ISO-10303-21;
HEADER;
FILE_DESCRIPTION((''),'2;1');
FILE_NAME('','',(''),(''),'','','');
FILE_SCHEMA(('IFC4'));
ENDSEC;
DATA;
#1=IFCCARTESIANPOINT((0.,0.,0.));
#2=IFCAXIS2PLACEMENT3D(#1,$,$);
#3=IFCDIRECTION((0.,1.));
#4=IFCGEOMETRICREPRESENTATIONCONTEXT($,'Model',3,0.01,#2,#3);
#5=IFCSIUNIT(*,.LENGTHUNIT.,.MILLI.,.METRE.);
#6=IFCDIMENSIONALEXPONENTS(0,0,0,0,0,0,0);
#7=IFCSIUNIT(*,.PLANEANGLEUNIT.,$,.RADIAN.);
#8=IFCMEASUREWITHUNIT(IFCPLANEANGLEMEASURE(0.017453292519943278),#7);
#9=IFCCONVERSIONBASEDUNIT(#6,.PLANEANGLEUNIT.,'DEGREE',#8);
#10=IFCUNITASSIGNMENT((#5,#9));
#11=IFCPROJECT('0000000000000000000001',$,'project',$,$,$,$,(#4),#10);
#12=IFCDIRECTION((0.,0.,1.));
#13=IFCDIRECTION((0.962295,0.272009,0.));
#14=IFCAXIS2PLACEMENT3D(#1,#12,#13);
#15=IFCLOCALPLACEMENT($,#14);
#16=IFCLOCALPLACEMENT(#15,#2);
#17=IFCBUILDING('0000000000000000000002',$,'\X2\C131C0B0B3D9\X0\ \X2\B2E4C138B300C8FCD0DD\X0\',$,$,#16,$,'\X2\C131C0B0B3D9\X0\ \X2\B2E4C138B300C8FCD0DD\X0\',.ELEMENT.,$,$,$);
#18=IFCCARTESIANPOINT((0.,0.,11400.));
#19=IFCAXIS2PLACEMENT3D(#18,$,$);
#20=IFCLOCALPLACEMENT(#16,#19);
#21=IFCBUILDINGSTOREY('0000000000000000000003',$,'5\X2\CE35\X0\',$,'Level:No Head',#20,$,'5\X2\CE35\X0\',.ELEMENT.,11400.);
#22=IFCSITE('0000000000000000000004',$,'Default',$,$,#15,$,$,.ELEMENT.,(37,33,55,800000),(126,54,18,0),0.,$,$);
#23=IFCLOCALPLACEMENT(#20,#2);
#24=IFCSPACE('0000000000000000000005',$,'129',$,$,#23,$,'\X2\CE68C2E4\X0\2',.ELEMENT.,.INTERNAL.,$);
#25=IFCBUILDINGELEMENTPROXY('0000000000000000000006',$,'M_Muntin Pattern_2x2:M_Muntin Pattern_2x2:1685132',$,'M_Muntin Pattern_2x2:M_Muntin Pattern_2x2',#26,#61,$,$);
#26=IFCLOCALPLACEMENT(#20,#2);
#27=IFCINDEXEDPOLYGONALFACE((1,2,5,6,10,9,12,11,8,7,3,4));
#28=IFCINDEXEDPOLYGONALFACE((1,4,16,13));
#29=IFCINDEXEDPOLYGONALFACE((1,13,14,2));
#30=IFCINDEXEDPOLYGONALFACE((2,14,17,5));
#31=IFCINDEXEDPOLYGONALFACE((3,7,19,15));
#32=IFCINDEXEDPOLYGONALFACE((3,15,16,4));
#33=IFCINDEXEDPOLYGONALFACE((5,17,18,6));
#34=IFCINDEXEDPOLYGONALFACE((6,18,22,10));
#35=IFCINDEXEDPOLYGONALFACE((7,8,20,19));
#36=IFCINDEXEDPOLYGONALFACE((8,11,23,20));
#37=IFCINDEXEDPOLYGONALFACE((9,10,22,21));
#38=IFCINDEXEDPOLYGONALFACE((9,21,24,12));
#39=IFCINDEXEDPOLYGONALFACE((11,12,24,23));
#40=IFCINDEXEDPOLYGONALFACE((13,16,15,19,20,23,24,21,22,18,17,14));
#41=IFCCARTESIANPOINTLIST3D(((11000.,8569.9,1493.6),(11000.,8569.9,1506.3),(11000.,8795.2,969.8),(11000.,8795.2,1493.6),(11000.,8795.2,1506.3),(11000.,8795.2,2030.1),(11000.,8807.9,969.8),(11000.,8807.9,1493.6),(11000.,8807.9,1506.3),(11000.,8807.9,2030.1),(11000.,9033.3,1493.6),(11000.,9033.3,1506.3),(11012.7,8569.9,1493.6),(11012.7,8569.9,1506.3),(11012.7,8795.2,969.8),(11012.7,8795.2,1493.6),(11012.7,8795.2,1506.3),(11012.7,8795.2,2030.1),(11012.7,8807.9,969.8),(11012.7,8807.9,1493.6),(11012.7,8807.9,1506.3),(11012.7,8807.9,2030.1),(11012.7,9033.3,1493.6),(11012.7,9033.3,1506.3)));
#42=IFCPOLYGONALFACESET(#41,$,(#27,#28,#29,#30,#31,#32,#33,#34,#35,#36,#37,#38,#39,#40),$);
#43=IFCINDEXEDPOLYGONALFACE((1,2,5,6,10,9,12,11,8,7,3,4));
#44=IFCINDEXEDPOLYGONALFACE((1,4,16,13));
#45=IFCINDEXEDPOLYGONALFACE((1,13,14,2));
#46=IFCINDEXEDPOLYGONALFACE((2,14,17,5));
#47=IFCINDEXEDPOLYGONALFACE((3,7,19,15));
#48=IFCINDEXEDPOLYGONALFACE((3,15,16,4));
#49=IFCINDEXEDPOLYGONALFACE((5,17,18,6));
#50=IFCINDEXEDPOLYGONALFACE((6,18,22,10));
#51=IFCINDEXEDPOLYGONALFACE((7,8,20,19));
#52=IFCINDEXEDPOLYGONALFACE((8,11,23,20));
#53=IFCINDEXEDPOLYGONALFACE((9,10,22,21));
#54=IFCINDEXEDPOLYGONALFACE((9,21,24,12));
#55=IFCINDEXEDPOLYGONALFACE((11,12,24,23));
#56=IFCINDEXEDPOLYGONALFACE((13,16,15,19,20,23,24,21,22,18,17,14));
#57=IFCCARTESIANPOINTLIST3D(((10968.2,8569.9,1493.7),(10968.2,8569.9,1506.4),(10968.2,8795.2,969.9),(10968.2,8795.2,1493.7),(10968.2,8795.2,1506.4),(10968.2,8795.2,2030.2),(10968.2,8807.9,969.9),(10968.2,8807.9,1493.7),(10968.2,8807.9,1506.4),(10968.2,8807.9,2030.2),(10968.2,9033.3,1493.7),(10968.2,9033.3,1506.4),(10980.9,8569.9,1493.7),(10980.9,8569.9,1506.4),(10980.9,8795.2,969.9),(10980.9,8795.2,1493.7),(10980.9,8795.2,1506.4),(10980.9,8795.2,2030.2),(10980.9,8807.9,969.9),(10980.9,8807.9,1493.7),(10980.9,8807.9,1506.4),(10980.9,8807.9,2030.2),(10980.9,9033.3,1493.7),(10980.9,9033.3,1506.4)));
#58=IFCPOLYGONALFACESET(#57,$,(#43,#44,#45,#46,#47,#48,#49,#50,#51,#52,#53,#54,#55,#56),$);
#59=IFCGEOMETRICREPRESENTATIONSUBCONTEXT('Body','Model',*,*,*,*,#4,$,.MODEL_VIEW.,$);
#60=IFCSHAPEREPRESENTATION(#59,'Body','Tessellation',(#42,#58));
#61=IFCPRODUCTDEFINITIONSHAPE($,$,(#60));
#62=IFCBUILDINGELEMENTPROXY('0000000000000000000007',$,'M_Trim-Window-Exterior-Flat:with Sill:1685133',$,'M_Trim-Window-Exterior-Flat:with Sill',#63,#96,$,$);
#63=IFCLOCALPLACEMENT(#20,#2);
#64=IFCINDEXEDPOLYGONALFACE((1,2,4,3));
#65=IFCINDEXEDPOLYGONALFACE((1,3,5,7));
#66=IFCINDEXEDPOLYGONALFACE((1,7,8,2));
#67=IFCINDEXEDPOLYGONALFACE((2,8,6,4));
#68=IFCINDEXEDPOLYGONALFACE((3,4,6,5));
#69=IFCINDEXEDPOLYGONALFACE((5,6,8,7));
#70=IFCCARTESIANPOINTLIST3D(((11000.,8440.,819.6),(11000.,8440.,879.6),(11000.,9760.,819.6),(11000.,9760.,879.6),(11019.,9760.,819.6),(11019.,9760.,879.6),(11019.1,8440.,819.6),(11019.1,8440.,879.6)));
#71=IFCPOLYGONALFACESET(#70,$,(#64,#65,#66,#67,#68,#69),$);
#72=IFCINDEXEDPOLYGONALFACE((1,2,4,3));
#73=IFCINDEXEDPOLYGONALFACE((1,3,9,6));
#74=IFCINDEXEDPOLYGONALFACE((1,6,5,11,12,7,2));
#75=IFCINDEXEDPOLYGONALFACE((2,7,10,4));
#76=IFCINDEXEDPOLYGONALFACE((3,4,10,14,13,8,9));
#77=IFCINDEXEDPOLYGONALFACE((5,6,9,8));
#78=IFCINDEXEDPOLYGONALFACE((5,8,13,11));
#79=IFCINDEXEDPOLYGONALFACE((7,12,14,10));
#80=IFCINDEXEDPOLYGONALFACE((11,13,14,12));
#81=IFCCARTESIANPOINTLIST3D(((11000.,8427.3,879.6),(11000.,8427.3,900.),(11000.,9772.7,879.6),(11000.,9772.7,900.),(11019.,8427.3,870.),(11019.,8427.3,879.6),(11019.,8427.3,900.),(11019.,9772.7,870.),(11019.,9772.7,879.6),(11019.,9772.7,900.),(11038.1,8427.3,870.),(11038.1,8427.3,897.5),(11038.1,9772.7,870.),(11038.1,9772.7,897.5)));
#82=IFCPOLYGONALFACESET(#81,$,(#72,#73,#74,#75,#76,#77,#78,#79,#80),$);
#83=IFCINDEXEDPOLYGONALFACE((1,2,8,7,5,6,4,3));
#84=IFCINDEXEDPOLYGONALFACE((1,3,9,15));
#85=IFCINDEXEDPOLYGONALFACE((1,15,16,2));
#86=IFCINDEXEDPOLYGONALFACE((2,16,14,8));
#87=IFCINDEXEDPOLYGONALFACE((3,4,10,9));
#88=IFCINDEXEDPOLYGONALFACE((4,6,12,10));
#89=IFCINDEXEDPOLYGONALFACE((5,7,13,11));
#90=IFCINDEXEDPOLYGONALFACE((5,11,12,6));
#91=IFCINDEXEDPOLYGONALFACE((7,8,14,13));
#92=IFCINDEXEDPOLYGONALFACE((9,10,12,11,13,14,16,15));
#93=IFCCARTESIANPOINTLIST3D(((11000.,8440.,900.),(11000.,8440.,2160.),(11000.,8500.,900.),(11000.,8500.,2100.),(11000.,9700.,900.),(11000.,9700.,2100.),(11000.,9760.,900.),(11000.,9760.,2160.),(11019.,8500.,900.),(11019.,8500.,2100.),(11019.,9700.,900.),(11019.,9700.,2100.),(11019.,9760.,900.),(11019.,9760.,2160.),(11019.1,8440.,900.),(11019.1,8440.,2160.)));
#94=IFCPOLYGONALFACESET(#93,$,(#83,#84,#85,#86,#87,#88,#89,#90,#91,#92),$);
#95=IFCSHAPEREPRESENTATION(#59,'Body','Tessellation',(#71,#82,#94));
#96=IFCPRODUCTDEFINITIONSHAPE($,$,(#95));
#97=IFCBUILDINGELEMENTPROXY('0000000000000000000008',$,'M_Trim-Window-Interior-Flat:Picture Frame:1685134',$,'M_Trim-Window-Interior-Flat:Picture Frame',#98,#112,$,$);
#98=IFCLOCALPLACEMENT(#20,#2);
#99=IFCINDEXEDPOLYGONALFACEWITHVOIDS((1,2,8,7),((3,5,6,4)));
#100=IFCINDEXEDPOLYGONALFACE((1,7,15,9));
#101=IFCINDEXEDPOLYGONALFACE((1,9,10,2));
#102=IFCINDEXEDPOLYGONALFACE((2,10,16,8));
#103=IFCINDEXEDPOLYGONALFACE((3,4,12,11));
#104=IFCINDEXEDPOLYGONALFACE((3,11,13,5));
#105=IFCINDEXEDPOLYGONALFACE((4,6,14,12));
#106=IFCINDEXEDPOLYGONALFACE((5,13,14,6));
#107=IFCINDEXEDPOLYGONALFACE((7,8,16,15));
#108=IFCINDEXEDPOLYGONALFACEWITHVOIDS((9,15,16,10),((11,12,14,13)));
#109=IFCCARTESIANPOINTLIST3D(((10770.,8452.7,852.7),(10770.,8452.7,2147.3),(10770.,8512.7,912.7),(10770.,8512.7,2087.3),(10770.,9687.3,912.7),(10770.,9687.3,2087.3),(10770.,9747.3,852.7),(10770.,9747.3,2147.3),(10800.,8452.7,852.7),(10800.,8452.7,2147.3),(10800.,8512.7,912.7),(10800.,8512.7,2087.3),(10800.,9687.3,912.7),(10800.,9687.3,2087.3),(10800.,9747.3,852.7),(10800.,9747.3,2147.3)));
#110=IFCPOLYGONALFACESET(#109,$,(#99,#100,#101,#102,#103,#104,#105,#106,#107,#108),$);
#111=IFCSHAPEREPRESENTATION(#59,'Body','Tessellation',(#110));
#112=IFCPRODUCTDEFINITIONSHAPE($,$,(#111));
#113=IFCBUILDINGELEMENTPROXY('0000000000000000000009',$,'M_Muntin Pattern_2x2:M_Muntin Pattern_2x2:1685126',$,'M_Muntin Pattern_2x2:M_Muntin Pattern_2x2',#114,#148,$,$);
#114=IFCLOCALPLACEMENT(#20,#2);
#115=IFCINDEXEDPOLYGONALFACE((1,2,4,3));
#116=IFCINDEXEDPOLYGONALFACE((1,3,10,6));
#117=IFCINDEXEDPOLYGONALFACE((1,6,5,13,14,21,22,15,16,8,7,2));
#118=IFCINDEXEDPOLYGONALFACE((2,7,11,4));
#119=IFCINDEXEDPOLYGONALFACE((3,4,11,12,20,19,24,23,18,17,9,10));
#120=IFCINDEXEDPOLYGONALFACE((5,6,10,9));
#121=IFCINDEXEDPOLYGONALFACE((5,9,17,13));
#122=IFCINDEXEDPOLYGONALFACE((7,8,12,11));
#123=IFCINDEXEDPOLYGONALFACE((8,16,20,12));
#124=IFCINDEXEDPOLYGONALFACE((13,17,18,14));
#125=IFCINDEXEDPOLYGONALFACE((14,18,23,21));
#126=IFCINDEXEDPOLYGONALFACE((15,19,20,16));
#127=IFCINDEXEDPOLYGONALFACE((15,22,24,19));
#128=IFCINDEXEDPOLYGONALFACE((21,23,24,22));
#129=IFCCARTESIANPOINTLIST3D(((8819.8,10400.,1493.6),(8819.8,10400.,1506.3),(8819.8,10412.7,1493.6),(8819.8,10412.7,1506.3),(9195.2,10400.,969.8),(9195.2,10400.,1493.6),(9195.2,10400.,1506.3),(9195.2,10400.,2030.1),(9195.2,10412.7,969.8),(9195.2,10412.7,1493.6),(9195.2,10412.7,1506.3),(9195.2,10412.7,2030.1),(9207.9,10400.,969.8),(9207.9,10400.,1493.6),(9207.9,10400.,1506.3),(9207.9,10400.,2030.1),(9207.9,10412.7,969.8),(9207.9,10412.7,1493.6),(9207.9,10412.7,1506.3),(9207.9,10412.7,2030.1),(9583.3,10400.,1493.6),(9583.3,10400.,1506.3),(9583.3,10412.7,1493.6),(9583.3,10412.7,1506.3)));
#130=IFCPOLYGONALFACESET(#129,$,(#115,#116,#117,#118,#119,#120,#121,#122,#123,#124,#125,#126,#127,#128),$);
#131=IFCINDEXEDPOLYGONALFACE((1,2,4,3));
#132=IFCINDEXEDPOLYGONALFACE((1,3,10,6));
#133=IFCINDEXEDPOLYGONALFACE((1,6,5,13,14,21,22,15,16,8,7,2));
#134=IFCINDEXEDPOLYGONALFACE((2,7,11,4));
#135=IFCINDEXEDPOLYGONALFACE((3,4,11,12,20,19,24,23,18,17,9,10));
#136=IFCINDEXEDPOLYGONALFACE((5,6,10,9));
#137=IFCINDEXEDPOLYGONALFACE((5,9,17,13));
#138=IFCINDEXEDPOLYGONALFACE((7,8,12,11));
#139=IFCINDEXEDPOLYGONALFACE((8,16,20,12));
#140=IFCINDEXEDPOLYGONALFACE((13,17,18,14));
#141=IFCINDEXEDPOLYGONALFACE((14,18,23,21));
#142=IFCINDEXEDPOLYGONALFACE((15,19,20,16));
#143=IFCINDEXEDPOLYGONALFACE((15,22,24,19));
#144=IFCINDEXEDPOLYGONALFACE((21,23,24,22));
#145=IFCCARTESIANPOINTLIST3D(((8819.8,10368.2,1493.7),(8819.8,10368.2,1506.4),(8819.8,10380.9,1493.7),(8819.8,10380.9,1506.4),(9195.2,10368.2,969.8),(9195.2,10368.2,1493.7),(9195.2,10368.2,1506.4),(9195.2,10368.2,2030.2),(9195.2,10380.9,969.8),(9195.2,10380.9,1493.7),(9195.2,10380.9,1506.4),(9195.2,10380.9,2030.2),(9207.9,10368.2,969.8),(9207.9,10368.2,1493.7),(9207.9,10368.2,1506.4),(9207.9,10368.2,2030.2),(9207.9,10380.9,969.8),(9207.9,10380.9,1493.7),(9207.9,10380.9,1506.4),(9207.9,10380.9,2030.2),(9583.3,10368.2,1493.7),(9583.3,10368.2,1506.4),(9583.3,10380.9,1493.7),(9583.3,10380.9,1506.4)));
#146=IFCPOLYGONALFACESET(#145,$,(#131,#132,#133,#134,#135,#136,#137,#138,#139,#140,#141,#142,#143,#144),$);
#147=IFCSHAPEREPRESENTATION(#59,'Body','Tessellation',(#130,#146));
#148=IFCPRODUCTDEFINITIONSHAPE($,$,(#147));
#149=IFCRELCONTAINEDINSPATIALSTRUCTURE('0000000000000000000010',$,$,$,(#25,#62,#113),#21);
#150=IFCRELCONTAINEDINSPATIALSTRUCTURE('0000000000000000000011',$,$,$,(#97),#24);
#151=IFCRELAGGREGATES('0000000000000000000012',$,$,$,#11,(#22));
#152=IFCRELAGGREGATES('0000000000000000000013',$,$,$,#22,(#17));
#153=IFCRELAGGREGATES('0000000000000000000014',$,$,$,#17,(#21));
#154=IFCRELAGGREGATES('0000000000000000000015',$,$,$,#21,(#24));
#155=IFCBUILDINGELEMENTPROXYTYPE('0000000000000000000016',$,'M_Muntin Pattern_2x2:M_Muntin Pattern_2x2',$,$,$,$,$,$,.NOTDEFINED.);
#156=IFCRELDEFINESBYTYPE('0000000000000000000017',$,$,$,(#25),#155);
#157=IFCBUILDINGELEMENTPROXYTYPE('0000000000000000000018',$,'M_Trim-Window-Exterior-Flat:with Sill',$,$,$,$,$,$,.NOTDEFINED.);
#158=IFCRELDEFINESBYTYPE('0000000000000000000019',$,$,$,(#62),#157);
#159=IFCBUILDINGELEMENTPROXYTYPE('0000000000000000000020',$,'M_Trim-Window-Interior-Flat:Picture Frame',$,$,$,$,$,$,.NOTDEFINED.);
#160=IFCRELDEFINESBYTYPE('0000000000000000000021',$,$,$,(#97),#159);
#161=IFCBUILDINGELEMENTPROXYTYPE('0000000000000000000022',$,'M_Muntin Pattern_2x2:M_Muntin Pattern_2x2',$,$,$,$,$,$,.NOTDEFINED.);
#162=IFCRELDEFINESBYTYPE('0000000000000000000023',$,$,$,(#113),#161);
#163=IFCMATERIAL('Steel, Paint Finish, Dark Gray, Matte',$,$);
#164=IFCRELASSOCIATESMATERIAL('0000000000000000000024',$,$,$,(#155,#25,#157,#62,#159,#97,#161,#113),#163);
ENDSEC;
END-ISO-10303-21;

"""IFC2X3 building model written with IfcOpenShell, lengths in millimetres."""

from ifc_helpers import new_model, entity, si_unit, converted_unit, direction, frame, frame_2d, origin, place, context, subcontext, project, spatial, polyline, rectangle, outline, extrude, source, transform, mapped, material, type_object, type_shapes, element, save


model = new_model("IFC2X3")

# Units and contexts
model_context = context("Model", 3, precision=0.01, world=origin(), true_north=direction((0.0, 1.0)))
body_context = subcontext(model_context, "Body", "Model", "MODEL_VIEW")
ifc_project = project(units=[si_unit("LENGTHUNIT", "METRE", prefix="MILLI"), converted_unit("PLANEANGLEUNIT", "DEGREE", entity("IfcPlaneAngleMeasure", 0.017453292519943278), si_unit("PLANEANGLEUNIT", "RADIAN"), dimensions=[0, 0, 0, 0, 0, 0, 0])], contexts=[model_context])

# Site, building, storey
site_placement = place(None, frame((0.0, 0.0, 0.0), z_axis=(0.0, 0.0, 1.0), x_axis=(0.962295, 0.272009, 0.0)))
site = spatial("IfcSite", under=ifc_project, at=site_placement, Name="Default", CompositionType="ELEMENT", RefLatitude=(37, 33, 55, 800000), RefLongitude=(126, 54, 18, 0), RefElevation=0.0)
building_placement = place(site_placement, origin())
building = spatial("IfcBuilding", under=site, at=building_placement, Name="성산동 다세대주택", LongName="성산동 다세대주택", CompositionType="ELEMENT")
storey_placement = place(building_placement, frame((0.0, 0.0, 11400.0)))
storey = spatial("IfcBuildingStorey", under=building, at=storey_placement, Name="5층", ObjectType="Level:No Head", LongName="5층", CompositionType="ELEMENT", Elevation=11400.0)

# Shared definitions
space_1_placement = place(storey_placement, origin())
space_1 = spatial("IfcSpace", under=storey, at=space_1_placement, Name="129", LongName="침실2", CompositionType="ELEMENT", InteriorOrExteriorSpace="INTERNAL")

# Building element proxies
ifc_material_1 = material(Name="Steel, Paint Finish, Dark Gray, Matte")
building_element_proxy_type_1 = type_object("IfcBuildingElementProxyType", Name="M_Muntin Pattern_2x2:M_Muntin Pattern_2x2", PredefinedType="NOTDEFINED", material=ifc_material_1)
shared_shape_1 = source(origin(), body_context, "Body", "SweptSolid", [
    extrude(outline(polyline([(6.4, -6.4), (530.1, -6.4), (530.1, 6.3), (6.4, 6.3), (6.4, 231.7), (-6.3, 231.7), (-6.3, 6.3), (-530.2, 6.3), (-530.2, -6.4), (-6.3, -6.4), (-6.3, -231.7), (6.4, -231.7), (6.4, -6.4)])), frame((0.0, -22.2, 530.1), z_axis=(0.0, 1.0, 0.0), x_axis=(0.0, 0.0, 1.0)), (0.0, 0.0, 1.0), 12.7),
    extrude(outline(polyline([(6.4, -6.4), (530.2, -6.4), (530.2, 6.3), (6.4, 6.3), (6.4, 231.7), (-6.3, 231.7), (-6.3, 6.3), (-530.2, 6.3), (-530.2, -6.4), (-6.3, -6.4), (-6.3, -231.7), (6.4, -231.7), (6.4, -6.4)])), frame((0.0, 9.5, 530.2), z_axis=(0.0, 1.0, 0.0), x_axis=(0.0, 0.0, 1.0)), (0.0, 0.0, 1.0), 12.7),
])
type_shapes(building_element_proxy_type_1, [shared_shape_1])
proxy_1_placement = place(storey_placement, frame((10990.5, 8801.6, 969.9), z_axis=(0.0, 0.0, 1.0), x_axis=(0.0, 1.0, 0.0)))
element("IfcBuildingElementProxy", 1, at=proxy_1_placement, inside=storey, type_object=building_element_proxy_type_1, material=ifc_material_1, Name="M_Muntin Pattern_2x2:M_Muntin Pattern_2x2:1685132", ObjectType="M_Muntin Pattern_2x2:M_Muntin Pattern_2x2", context=body_context, shape_type="MappedRepresentation", body=[
    mapped(shared_shape_1, transform((0.0, 0.0, 0.0), scale=1.0)),
])
building_element_proxy_type_2 = type_object("IfcBuildingElementProxyType", Name="M_Trim-Window-Exterior-Flat:with Sill", PredefinedType="NOTDEFINED", material=ifc_material_1)
shared_shape_2 = source(origin(), body_context, "Body", "SweptSolid", [
    extrude(rectangle(XDim=1320.0, YDim=60.0, at=frame_2d((0.0, 0.0), x_axis=(1.0, 0.0))), frame((0.0, -1250.4, 0.0), z_axis=(0.0, 0.0, 1.0), x_axis=(-1.0, 0.0, 0.0)), (0.0, 0.0, 1.0), 19.0),
    extrude(outline(polyline([(-19.0, -15.2), (0.0, -15.2), (0.0, -5.7), (19.0, -5.7), (19.0, 14.8), (0.0, 14.8), (-19.0, 12.3), (-19.0, -15.2)])), frame((-672.7, -1214.8, 19.0), z_axis=(1.0, 0.0, 0.0), x_axis=(0.0, 0.0, -1.0)), (0.0, 0.0, 1.0), 1345.4),
    extrude(outline(polyline([(-645.0, -660.0), (615.0, -660.0), (615.0, -600.0), (-585.0, -600.0), (-585.0, 600.0), (615.0, 600.0), (615.0, 660.0), (-645.0, 660.0), (-645.0, -660.0)])), frame((0.0, -585.0, 0.0), z_axis=(0.0, 0.0, 1.0), x_axis=(0.0, -1.0, 0.0)), (0.0, 0.0, 1.0), 19.0),
])
type_shapes(building_element_proxy_type_2, [shared_shape_2])
proxy_2_placement = place(storey_placement, frame((11000.0, 9100.0, 2100.0), z_axis=(1.0, 0.0, 0.0), x_axis=(0.0, 1.0, 0.0)))
element("IfcBuildingElementProxy", 2, at=proxy_2_placement, inside=storey, type_object=building_element_proxy_type_2, material=ifc_material_1, Name="M_Trim-Window-Exterior-Flat:with Sill:1685133", ObjectType="M_Trim-Window-Exterior-Flat:with Sill", context=body_context, shape_type="MappedRepresentation", body=[
    mapped(shared_shape_2, transform((0.0, 0.0, 0.0), scale=1.0)),
])
building_element_proxy_type_3 = type_object("IfcBuildingElementProxyType", Name="M_Trim-Window-Interior-Flat:Picture Frame", PredefinedType="NOTDEFINED", material=ifc_material_1)
shared_shape_3 = source(origin(), body_context, "Body", "SweptSolid", [
    extrude(outline(polyline([(-647.3, -647.3), (647.3, -647.3), (647.3, 647.3), (-647.3, 647.3), (-647.3, -647.3)]), holes=[polyline([(-587.3, -587.3), (-587.3, 587.3), (587.3, 587.3), (587.3, -587.3), (-587.3, -587.3)])]), frame((0.0, -600.0, 0.0), z_axis=(0.0, 0.0, 1.0), x_axis=(-1.0, 0.0, 0.0)), (0.0, 0.0, 1.0), 30.0),
])
type_shapes(building_element_proxy_type_3, [shared_shape_3])
proxy_3_placement = place(space_1_placement, frame((10800.0, 9100.0, 2100.0), z_axis=(-1.0, 0.0, 0.0), x_axis=(0.0, -1.0, 0.0)))
element("IfcBuildingElementProxy", 3, at=proxy_3_placement, inside=space_1, type_object=building_element_proxy_type_3, material=ifc_material_1, Name="M_Trim-Window-Interior-Flat:Picture Frame:1685134", ObjectType="M_Trim-Window-Interior-Flat:Picture Frame", context=body_context, shape_type="MappedRepresentation", body=[
    mapped(shared_shape_3, transform((0.0, 0.0, 0.0), scale=1.0)),
])
building_element_proxy_type_4 = type_object("IfcBuildingElementProxyType", Name="M_Muntin Pattern_2x2:M_Muntin Pattern_2x2", PredefinedType="NOTDEFINED", material=ifc_material_1)
shared_shape_4 = source(origin(), body_context, "Body", "SweptSolid", [
    extrude(outline(polyline([(6.4, -6.4), (530.1, -6.4), (530.1, 6.3), (6.4, 6.3), (6.4, 381.7), (-6.3, 381.7), (-6.3, 6.3), (-530.2, 6.3), (-530.2, -6.4), (-6.3, -6.4), (-6.3, -381.7), (6.4, -381.7), (6.4, -6.4)])), frame((0.0, 9.5, 530.1), z_axis=(0.0, 1.0, 0.0), x_axis=(0.0, 0.0, 1.0)), (0.0, 0.0, 1.0), 12.7),
    extrude(outline(polyline([(6.4, -6.4), (530.2, -6.4), (530.2, 6.3), (6.4, 6.3), (6.4, 381.7), (-6.3, 381.7), (-6.3, 6.3), (-530.2, 6.3), (-530.2, -6.4), (-6.3, -6.4), (-6.3, -381.7), (6.4, -381.7), (6.4, -6.4)])), frame((0.0, -22.2, 530.2), z_axis=(0.0, 1.0, 0.0), x_axis=(0.0, 0.0, 1.0)), (0.0, 0.0, 1.0), 12.7),
])
type_shapes(building_element_proxy_type_4, [shared_shape_4])
proxy_4_placement = place(storey_placement, frame((9201.6, 10390.5, 969.8)))
element("IfcBuildingElementProxy", 4, at=proxy_4_placement, inside=storey, type_object=building_element_proxy_type_4, material=ifc_material_1, Name="M_Muntin Pattern_2x2:M_Muntin Pattern_2x2:1685126", ObjectType="M_Muntin Pattern_2x2:M_Muntin Pattern_2x2", context=body_context, shape_type="MappedRepresentation", body=[
    mapped(shared_shape_4, transform((0.0, 0.0, 0.0), scale=1.0)),
])

save(model, "model.ifc")
